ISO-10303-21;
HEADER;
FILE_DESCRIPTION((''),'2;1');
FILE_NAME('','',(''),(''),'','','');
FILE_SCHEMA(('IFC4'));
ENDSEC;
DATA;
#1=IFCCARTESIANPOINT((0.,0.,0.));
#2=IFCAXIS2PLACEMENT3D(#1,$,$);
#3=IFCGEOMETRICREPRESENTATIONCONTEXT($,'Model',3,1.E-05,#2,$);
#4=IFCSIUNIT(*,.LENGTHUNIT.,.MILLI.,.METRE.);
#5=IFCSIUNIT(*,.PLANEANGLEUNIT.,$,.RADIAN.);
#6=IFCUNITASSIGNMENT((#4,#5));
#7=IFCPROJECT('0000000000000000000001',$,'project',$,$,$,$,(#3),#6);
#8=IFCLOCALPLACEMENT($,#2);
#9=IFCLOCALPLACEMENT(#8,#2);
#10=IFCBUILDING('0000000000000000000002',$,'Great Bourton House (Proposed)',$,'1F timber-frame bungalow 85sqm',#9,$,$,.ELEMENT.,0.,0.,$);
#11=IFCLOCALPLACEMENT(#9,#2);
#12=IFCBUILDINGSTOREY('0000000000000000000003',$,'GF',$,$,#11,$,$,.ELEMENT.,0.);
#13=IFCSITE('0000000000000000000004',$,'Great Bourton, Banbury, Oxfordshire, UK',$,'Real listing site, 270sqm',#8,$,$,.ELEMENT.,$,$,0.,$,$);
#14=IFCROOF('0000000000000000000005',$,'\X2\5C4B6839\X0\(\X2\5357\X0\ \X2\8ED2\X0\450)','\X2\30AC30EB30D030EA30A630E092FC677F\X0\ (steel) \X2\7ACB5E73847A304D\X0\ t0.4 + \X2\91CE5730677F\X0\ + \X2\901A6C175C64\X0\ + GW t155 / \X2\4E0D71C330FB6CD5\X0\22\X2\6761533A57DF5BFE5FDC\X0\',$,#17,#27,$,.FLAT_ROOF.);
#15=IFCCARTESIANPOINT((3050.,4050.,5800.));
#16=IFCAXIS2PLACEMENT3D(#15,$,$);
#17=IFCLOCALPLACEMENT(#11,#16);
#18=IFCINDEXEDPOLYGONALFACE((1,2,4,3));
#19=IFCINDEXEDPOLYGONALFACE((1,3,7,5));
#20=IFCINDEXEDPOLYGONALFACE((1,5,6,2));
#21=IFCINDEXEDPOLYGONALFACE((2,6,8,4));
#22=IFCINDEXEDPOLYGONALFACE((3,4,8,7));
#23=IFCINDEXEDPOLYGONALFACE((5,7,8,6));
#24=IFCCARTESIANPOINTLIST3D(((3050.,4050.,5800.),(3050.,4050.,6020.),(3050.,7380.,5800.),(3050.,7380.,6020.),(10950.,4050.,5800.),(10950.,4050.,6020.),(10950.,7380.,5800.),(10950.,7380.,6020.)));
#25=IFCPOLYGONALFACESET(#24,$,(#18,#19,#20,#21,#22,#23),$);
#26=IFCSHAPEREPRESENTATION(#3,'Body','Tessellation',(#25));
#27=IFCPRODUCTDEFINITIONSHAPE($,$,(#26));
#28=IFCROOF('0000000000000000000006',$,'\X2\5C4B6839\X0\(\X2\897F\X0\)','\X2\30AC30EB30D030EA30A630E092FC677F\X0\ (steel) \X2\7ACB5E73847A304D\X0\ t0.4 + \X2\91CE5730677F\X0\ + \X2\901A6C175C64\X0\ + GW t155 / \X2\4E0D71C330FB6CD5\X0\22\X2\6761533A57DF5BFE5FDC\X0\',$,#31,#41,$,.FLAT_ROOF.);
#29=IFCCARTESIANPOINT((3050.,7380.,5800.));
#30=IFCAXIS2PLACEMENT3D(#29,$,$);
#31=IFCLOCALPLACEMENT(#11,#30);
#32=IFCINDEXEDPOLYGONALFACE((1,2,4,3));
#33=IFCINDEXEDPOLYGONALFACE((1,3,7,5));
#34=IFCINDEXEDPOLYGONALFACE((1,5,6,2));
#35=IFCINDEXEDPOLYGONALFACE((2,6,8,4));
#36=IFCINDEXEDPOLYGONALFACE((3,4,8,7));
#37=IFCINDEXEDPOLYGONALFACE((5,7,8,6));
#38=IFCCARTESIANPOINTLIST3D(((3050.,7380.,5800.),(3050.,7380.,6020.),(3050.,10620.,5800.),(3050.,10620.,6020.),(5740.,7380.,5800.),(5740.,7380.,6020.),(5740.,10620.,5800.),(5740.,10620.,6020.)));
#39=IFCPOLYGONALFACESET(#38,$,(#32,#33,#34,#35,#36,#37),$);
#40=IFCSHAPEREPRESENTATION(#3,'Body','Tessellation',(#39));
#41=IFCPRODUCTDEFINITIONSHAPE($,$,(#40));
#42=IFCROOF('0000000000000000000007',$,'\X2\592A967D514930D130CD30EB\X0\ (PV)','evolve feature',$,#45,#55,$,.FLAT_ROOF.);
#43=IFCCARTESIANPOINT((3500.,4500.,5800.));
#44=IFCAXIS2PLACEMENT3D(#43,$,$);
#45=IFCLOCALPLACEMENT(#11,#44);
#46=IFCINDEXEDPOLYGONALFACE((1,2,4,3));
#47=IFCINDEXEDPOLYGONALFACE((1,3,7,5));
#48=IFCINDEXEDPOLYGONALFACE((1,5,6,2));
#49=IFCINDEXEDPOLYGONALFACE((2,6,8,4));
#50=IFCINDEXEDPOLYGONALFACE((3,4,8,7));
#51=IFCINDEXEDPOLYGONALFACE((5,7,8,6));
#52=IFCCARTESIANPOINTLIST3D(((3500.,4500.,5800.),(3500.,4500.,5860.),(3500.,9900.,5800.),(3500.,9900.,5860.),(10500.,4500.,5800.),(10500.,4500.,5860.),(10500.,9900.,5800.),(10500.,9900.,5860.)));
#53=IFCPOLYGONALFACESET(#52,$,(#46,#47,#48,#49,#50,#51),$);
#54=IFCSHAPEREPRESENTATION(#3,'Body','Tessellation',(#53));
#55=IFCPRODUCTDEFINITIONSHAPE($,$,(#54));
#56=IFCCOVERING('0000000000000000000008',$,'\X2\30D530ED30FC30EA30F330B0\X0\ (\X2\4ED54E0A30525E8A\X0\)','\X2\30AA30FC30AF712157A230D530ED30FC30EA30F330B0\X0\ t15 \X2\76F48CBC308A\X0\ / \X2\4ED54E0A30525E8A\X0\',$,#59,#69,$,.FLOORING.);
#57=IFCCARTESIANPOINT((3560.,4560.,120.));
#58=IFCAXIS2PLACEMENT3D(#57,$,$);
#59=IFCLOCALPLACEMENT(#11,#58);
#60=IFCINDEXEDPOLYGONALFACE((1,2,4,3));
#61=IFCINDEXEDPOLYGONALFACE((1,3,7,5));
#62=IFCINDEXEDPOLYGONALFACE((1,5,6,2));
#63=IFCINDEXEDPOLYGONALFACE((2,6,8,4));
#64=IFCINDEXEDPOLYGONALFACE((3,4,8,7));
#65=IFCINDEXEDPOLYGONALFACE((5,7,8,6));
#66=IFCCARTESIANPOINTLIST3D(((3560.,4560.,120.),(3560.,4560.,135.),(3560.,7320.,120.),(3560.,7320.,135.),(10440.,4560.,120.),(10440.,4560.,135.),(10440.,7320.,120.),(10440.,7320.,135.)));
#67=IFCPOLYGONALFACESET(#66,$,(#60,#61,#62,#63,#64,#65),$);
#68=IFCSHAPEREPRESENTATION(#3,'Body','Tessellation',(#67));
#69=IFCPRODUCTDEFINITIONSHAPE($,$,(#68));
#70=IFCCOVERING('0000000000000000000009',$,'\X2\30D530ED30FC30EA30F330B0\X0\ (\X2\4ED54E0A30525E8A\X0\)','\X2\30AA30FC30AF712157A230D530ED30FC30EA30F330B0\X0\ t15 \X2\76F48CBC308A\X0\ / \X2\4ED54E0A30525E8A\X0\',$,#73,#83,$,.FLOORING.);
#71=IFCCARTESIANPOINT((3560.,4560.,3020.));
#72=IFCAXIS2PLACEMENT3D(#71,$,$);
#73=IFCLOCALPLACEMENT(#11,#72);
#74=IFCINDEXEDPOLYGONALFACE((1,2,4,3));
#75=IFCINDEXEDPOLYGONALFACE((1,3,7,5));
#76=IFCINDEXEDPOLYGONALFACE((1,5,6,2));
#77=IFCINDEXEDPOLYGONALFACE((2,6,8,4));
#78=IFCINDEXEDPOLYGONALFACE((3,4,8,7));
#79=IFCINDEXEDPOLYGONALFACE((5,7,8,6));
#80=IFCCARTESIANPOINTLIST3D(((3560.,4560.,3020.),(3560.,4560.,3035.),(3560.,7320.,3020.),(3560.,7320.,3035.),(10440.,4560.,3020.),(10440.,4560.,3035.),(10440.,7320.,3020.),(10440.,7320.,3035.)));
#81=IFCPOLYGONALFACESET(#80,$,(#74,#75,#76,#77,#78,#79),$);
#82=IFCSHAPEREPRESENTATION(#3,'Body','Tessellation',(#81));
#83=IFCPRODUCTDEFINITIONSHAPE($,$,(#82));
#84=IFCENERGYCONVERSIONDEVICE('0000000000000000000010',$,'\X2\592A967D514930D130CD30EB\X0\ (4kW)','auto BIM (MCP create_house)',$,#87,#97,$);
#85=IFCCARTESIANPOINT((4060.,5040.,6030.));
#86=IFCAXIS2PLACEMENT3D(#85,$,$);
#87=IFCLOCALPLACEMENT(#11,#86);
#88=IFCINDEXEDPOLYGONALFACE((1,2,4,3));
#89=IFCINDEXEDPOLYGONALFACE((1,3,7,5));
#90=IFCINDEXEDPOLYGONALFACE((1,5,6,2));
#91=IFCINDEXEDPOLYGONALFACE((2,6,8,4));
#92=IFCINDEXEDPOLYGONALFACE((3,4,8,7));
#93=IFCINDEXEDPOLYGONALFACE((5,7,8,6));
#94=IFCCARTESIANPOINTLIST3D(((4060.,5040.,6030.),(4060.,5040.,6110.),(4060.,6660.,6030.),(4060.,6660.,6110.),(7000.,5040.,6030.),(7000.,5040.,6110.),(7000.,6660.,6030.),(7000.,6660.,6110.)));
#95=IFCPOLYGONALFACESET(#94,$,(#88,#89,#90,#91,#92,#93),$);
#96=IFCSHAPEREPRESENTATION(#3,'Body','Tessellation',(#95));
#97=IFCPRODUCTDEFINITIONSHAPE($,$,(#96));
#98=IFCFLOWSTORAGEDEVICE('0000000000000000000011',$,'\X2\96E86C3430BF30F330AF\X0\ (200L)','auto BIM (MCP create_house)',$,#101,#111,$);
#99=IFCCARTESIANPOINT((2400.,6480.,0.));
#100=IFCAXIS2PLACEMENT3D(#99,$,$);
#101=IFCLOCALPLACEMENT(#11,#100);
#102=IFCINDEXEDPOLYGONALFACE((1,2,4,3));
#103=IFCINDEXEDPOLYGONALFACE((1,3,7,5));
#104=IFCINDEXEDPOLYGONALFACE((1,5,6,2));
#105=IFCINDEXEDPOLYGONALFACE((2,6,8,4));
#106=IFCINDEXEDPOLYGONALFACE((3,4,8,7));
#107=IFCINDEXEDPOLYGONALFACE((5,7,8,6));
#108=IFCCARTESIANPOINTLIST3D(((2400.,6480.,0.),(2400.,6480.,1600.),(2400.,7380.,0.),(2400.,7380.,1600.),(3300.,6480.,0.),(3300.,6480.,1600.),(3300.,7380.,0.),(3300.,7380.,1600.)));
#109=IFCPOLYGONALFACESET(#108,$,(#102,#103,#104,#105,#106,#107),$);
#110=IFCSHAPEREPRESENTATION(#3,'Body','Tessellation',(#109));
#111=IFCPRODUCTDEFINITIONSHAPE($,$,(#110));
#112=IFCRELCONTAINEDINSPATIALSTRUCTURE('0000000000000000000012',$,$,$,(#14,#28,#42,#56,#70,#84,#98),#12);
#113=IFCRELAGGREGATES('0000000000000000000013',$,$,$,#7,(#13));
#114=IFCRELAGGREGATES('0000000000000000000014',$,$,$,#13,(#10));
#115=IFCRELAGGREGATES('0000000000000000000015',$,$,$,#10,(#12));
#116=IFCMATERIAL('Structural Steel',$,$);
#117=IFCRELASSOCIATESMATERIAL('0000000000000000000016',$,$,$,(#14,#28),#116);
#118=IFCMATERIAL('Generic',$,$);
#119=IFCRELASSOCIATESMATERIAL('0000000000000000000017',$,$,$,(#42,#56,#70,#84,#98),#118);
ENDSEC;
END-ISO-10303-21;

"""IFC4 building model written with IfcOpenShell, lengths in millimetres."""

from ifc_helpers import new_model, si_unit, frame, frame_2d, origin, place, context, project, spatial, rectangle, extrude, material, element, save


model = new_model("IFC4")

# Units and contexts
model_context = context("Model", 3, precision=1e-05, world=origin())
ifc_project = project(units=[si_unit("LENGTHUNIT", "METRE", prefix="MILLI"), si_unit("PLANEANGLEUNIT", "RADIAN")], contexts=[model_context])

# Site, building, storey
site_placement = place(None, origin())
site = spatial("IfcSite", under=ifc_project, at=site_placement, Name="Great Bourton, Banbury, Oxfordshire, UK", ObjectType="Real listing site, 270sqm", CompositionType="ELEMENT", RefElevation=0.0)
building_placement = place(site_placement, origin())
building = spatial("IfcBuilding", under=site, at=building_placement, Name="Great Bourton House (Proposed)", ObjectType="1F timber-frame bungalow 85sqm", CompositionType="ELEMENT", ElevationOfRefHeight=0.0, ElevationOfTerrain=0.0)
storey_placement = place(building_placement, origin())
storey = spatial("IfcBuildingStorey", under=building, at=storey_placement, Name="GF", CompositionType="ELEMENT", Elevation=0.0)

# Shared definitions
ifc_material_1 = material(Name="Generic")

# Roofs
ifc_material_2 = material(Name="Structural Steel")
roof_1_placement = place(storey_placement, frame((3050.0, 4050.0, 5800.0)))
element("IfcRoof", 1, at=roof_1_placement, inside=storey, material=ifc_material_2, Name="屋根(南 軒450)", Description="ガルバリウム鋼板 (steel) 立平葺き t0.4 + 野地板 + 通気層 + GW t155 / 不燃・法22条区域対応", PredefinedType="FLAT_ROOF", context=model_context, shape_type="SweptSolid", body=[
    extrude(rectangle(XDim=7900.0, YDim=3330.0, at=frame_2d((3950.0, 1665.0))), frame((3050.0, 4050.0, 5800.0)), (0.0, 0.0, 1.0), 220.0),
])
roof_2_placement = place(storey_placement, frame((3050.0, 7380.0, 5800.0)))
element("IfcRoof", 2, at=roof_2_placement, inside=storey, material=ifc_material_2, Name="屋根(西)", Description="ガルバリウム鋼板 (steel) 立平葺き t0.4 + 野地板 + 通気層 + GW t155 / 不燃・法22条区域対応", PredefinedType="FLAT_ROOF", context=model_context, shape_type="SweptSolid", body=[
    extrude(rectangle(XDim=2690.0, YDim=3240.0, at=frame_2d((1345.0, 1620.0))), frame((3050.0, 7380.0, 5800.0)), (0.0, 0.0, 1.0), 220.0),
])
roof_3_placement = place(storey_placement, frame((3500.0, 4500.0, 5800.0)))
element("IfcRoof", 3, at=roof_3_placement, inside=storey, material=ifc_material_1, Name="太陽光パネル (PV)", Description="evolve feature", PredefinedType="FLAT_ROOF", context=model_context, shape_type="SweptSolid", body=[
    extrude(rectangle(XDim=7000.0, YDim=5400.0, at=frame_2d((3500.0, 2700.0))), frame((3500.0, 4500.0, 5800.0)), (0.0, 0.0, 1.0), 60.0),
])

# Coverings
covering_1_placement = place(storey_placement, frame((3560.0, 4560.0, 120.0)))
element("IfcCovering", 4, at=covering_1_placement, inside=storey, material=ifc_material_1, Name="フローリング (仕上げ床)", Description="オーク無垢フローリング t15 直貼り / 仕上げ床", PredefinedType="FLOORING", context=model_context, shape_type="SweptSolid", body=[
    extrude(rectangle(XDim=6880.0, YDim=2760.0, at=frame_2d((3440.0, 1380.0))), frame((3560.0, 4560.0, 120.0)), (0.0, 0.0, 1.0), 15.0),
])
covering_2_placement = place(storey_placement, frame((3560.0, 4560.0, 3020.0)))
element("IfcCovering", 5, at=covering_2_placement, inside=storey, material=ifc_material_1, Name="フローリング (仕上げ床)", Description="オーク無垢フローリング t15 直貼り / 仕上げ床", PredefinedType="FLOORING", context=model_context, shape_type="SweptSolid", body=[
    extrude(rectangle(XDim=6880.0, YDim=2760.0, at=frame_2d((3440.0, 1380.0))), frame((3560.0, 4560.0, 3020.0)), (0.0, 0.0, 1.0), 15.0),
])

# Energy conversion device
energy_conversion_device_placement = place(storey_placement, frame((4060.0, 5040.0, 6030.0)))
element("IfcEnergyConversionDevice", 6, at=energy_conversion_device_placement, inside=storey, material=ifc_material_1, Name="太陽光パネル (4kW)", Description="auto BIM (MCP create_house)", context=model_context, shape_type="SweptSolid", body=[
    extrude(rectangle(XDim=2940.0, YDim=1620.0, at=frame_2d((1470.0, 810.0))), frame((4060.0, 5040.0, 6030.0)), (0.0, 0.0, 1.0), 80.0),
])

# Flow storage device
flow_storage_device_placement = place(storey_placement, frame((2400.0, 6480.0, 0.0)))
element("IfcFlowStorageDevice", 7, at=flow_storage_device_placement, inside=storey, material=ifc_material_1, Name="雨水タンク (200L)", Description="auto BIM (MCP create_house)", context=model_context, shape_type="SweptSolid", body=[
    extrude(rectangle(XDim=900.0, YDim=900.0, at=frame_2d((450.0, 450.0))), frame((2400.0, 6480.0, 0.0)), (0.0, 0.0, 1.0), 1600.0),
])

save(model, "model.ifc")
